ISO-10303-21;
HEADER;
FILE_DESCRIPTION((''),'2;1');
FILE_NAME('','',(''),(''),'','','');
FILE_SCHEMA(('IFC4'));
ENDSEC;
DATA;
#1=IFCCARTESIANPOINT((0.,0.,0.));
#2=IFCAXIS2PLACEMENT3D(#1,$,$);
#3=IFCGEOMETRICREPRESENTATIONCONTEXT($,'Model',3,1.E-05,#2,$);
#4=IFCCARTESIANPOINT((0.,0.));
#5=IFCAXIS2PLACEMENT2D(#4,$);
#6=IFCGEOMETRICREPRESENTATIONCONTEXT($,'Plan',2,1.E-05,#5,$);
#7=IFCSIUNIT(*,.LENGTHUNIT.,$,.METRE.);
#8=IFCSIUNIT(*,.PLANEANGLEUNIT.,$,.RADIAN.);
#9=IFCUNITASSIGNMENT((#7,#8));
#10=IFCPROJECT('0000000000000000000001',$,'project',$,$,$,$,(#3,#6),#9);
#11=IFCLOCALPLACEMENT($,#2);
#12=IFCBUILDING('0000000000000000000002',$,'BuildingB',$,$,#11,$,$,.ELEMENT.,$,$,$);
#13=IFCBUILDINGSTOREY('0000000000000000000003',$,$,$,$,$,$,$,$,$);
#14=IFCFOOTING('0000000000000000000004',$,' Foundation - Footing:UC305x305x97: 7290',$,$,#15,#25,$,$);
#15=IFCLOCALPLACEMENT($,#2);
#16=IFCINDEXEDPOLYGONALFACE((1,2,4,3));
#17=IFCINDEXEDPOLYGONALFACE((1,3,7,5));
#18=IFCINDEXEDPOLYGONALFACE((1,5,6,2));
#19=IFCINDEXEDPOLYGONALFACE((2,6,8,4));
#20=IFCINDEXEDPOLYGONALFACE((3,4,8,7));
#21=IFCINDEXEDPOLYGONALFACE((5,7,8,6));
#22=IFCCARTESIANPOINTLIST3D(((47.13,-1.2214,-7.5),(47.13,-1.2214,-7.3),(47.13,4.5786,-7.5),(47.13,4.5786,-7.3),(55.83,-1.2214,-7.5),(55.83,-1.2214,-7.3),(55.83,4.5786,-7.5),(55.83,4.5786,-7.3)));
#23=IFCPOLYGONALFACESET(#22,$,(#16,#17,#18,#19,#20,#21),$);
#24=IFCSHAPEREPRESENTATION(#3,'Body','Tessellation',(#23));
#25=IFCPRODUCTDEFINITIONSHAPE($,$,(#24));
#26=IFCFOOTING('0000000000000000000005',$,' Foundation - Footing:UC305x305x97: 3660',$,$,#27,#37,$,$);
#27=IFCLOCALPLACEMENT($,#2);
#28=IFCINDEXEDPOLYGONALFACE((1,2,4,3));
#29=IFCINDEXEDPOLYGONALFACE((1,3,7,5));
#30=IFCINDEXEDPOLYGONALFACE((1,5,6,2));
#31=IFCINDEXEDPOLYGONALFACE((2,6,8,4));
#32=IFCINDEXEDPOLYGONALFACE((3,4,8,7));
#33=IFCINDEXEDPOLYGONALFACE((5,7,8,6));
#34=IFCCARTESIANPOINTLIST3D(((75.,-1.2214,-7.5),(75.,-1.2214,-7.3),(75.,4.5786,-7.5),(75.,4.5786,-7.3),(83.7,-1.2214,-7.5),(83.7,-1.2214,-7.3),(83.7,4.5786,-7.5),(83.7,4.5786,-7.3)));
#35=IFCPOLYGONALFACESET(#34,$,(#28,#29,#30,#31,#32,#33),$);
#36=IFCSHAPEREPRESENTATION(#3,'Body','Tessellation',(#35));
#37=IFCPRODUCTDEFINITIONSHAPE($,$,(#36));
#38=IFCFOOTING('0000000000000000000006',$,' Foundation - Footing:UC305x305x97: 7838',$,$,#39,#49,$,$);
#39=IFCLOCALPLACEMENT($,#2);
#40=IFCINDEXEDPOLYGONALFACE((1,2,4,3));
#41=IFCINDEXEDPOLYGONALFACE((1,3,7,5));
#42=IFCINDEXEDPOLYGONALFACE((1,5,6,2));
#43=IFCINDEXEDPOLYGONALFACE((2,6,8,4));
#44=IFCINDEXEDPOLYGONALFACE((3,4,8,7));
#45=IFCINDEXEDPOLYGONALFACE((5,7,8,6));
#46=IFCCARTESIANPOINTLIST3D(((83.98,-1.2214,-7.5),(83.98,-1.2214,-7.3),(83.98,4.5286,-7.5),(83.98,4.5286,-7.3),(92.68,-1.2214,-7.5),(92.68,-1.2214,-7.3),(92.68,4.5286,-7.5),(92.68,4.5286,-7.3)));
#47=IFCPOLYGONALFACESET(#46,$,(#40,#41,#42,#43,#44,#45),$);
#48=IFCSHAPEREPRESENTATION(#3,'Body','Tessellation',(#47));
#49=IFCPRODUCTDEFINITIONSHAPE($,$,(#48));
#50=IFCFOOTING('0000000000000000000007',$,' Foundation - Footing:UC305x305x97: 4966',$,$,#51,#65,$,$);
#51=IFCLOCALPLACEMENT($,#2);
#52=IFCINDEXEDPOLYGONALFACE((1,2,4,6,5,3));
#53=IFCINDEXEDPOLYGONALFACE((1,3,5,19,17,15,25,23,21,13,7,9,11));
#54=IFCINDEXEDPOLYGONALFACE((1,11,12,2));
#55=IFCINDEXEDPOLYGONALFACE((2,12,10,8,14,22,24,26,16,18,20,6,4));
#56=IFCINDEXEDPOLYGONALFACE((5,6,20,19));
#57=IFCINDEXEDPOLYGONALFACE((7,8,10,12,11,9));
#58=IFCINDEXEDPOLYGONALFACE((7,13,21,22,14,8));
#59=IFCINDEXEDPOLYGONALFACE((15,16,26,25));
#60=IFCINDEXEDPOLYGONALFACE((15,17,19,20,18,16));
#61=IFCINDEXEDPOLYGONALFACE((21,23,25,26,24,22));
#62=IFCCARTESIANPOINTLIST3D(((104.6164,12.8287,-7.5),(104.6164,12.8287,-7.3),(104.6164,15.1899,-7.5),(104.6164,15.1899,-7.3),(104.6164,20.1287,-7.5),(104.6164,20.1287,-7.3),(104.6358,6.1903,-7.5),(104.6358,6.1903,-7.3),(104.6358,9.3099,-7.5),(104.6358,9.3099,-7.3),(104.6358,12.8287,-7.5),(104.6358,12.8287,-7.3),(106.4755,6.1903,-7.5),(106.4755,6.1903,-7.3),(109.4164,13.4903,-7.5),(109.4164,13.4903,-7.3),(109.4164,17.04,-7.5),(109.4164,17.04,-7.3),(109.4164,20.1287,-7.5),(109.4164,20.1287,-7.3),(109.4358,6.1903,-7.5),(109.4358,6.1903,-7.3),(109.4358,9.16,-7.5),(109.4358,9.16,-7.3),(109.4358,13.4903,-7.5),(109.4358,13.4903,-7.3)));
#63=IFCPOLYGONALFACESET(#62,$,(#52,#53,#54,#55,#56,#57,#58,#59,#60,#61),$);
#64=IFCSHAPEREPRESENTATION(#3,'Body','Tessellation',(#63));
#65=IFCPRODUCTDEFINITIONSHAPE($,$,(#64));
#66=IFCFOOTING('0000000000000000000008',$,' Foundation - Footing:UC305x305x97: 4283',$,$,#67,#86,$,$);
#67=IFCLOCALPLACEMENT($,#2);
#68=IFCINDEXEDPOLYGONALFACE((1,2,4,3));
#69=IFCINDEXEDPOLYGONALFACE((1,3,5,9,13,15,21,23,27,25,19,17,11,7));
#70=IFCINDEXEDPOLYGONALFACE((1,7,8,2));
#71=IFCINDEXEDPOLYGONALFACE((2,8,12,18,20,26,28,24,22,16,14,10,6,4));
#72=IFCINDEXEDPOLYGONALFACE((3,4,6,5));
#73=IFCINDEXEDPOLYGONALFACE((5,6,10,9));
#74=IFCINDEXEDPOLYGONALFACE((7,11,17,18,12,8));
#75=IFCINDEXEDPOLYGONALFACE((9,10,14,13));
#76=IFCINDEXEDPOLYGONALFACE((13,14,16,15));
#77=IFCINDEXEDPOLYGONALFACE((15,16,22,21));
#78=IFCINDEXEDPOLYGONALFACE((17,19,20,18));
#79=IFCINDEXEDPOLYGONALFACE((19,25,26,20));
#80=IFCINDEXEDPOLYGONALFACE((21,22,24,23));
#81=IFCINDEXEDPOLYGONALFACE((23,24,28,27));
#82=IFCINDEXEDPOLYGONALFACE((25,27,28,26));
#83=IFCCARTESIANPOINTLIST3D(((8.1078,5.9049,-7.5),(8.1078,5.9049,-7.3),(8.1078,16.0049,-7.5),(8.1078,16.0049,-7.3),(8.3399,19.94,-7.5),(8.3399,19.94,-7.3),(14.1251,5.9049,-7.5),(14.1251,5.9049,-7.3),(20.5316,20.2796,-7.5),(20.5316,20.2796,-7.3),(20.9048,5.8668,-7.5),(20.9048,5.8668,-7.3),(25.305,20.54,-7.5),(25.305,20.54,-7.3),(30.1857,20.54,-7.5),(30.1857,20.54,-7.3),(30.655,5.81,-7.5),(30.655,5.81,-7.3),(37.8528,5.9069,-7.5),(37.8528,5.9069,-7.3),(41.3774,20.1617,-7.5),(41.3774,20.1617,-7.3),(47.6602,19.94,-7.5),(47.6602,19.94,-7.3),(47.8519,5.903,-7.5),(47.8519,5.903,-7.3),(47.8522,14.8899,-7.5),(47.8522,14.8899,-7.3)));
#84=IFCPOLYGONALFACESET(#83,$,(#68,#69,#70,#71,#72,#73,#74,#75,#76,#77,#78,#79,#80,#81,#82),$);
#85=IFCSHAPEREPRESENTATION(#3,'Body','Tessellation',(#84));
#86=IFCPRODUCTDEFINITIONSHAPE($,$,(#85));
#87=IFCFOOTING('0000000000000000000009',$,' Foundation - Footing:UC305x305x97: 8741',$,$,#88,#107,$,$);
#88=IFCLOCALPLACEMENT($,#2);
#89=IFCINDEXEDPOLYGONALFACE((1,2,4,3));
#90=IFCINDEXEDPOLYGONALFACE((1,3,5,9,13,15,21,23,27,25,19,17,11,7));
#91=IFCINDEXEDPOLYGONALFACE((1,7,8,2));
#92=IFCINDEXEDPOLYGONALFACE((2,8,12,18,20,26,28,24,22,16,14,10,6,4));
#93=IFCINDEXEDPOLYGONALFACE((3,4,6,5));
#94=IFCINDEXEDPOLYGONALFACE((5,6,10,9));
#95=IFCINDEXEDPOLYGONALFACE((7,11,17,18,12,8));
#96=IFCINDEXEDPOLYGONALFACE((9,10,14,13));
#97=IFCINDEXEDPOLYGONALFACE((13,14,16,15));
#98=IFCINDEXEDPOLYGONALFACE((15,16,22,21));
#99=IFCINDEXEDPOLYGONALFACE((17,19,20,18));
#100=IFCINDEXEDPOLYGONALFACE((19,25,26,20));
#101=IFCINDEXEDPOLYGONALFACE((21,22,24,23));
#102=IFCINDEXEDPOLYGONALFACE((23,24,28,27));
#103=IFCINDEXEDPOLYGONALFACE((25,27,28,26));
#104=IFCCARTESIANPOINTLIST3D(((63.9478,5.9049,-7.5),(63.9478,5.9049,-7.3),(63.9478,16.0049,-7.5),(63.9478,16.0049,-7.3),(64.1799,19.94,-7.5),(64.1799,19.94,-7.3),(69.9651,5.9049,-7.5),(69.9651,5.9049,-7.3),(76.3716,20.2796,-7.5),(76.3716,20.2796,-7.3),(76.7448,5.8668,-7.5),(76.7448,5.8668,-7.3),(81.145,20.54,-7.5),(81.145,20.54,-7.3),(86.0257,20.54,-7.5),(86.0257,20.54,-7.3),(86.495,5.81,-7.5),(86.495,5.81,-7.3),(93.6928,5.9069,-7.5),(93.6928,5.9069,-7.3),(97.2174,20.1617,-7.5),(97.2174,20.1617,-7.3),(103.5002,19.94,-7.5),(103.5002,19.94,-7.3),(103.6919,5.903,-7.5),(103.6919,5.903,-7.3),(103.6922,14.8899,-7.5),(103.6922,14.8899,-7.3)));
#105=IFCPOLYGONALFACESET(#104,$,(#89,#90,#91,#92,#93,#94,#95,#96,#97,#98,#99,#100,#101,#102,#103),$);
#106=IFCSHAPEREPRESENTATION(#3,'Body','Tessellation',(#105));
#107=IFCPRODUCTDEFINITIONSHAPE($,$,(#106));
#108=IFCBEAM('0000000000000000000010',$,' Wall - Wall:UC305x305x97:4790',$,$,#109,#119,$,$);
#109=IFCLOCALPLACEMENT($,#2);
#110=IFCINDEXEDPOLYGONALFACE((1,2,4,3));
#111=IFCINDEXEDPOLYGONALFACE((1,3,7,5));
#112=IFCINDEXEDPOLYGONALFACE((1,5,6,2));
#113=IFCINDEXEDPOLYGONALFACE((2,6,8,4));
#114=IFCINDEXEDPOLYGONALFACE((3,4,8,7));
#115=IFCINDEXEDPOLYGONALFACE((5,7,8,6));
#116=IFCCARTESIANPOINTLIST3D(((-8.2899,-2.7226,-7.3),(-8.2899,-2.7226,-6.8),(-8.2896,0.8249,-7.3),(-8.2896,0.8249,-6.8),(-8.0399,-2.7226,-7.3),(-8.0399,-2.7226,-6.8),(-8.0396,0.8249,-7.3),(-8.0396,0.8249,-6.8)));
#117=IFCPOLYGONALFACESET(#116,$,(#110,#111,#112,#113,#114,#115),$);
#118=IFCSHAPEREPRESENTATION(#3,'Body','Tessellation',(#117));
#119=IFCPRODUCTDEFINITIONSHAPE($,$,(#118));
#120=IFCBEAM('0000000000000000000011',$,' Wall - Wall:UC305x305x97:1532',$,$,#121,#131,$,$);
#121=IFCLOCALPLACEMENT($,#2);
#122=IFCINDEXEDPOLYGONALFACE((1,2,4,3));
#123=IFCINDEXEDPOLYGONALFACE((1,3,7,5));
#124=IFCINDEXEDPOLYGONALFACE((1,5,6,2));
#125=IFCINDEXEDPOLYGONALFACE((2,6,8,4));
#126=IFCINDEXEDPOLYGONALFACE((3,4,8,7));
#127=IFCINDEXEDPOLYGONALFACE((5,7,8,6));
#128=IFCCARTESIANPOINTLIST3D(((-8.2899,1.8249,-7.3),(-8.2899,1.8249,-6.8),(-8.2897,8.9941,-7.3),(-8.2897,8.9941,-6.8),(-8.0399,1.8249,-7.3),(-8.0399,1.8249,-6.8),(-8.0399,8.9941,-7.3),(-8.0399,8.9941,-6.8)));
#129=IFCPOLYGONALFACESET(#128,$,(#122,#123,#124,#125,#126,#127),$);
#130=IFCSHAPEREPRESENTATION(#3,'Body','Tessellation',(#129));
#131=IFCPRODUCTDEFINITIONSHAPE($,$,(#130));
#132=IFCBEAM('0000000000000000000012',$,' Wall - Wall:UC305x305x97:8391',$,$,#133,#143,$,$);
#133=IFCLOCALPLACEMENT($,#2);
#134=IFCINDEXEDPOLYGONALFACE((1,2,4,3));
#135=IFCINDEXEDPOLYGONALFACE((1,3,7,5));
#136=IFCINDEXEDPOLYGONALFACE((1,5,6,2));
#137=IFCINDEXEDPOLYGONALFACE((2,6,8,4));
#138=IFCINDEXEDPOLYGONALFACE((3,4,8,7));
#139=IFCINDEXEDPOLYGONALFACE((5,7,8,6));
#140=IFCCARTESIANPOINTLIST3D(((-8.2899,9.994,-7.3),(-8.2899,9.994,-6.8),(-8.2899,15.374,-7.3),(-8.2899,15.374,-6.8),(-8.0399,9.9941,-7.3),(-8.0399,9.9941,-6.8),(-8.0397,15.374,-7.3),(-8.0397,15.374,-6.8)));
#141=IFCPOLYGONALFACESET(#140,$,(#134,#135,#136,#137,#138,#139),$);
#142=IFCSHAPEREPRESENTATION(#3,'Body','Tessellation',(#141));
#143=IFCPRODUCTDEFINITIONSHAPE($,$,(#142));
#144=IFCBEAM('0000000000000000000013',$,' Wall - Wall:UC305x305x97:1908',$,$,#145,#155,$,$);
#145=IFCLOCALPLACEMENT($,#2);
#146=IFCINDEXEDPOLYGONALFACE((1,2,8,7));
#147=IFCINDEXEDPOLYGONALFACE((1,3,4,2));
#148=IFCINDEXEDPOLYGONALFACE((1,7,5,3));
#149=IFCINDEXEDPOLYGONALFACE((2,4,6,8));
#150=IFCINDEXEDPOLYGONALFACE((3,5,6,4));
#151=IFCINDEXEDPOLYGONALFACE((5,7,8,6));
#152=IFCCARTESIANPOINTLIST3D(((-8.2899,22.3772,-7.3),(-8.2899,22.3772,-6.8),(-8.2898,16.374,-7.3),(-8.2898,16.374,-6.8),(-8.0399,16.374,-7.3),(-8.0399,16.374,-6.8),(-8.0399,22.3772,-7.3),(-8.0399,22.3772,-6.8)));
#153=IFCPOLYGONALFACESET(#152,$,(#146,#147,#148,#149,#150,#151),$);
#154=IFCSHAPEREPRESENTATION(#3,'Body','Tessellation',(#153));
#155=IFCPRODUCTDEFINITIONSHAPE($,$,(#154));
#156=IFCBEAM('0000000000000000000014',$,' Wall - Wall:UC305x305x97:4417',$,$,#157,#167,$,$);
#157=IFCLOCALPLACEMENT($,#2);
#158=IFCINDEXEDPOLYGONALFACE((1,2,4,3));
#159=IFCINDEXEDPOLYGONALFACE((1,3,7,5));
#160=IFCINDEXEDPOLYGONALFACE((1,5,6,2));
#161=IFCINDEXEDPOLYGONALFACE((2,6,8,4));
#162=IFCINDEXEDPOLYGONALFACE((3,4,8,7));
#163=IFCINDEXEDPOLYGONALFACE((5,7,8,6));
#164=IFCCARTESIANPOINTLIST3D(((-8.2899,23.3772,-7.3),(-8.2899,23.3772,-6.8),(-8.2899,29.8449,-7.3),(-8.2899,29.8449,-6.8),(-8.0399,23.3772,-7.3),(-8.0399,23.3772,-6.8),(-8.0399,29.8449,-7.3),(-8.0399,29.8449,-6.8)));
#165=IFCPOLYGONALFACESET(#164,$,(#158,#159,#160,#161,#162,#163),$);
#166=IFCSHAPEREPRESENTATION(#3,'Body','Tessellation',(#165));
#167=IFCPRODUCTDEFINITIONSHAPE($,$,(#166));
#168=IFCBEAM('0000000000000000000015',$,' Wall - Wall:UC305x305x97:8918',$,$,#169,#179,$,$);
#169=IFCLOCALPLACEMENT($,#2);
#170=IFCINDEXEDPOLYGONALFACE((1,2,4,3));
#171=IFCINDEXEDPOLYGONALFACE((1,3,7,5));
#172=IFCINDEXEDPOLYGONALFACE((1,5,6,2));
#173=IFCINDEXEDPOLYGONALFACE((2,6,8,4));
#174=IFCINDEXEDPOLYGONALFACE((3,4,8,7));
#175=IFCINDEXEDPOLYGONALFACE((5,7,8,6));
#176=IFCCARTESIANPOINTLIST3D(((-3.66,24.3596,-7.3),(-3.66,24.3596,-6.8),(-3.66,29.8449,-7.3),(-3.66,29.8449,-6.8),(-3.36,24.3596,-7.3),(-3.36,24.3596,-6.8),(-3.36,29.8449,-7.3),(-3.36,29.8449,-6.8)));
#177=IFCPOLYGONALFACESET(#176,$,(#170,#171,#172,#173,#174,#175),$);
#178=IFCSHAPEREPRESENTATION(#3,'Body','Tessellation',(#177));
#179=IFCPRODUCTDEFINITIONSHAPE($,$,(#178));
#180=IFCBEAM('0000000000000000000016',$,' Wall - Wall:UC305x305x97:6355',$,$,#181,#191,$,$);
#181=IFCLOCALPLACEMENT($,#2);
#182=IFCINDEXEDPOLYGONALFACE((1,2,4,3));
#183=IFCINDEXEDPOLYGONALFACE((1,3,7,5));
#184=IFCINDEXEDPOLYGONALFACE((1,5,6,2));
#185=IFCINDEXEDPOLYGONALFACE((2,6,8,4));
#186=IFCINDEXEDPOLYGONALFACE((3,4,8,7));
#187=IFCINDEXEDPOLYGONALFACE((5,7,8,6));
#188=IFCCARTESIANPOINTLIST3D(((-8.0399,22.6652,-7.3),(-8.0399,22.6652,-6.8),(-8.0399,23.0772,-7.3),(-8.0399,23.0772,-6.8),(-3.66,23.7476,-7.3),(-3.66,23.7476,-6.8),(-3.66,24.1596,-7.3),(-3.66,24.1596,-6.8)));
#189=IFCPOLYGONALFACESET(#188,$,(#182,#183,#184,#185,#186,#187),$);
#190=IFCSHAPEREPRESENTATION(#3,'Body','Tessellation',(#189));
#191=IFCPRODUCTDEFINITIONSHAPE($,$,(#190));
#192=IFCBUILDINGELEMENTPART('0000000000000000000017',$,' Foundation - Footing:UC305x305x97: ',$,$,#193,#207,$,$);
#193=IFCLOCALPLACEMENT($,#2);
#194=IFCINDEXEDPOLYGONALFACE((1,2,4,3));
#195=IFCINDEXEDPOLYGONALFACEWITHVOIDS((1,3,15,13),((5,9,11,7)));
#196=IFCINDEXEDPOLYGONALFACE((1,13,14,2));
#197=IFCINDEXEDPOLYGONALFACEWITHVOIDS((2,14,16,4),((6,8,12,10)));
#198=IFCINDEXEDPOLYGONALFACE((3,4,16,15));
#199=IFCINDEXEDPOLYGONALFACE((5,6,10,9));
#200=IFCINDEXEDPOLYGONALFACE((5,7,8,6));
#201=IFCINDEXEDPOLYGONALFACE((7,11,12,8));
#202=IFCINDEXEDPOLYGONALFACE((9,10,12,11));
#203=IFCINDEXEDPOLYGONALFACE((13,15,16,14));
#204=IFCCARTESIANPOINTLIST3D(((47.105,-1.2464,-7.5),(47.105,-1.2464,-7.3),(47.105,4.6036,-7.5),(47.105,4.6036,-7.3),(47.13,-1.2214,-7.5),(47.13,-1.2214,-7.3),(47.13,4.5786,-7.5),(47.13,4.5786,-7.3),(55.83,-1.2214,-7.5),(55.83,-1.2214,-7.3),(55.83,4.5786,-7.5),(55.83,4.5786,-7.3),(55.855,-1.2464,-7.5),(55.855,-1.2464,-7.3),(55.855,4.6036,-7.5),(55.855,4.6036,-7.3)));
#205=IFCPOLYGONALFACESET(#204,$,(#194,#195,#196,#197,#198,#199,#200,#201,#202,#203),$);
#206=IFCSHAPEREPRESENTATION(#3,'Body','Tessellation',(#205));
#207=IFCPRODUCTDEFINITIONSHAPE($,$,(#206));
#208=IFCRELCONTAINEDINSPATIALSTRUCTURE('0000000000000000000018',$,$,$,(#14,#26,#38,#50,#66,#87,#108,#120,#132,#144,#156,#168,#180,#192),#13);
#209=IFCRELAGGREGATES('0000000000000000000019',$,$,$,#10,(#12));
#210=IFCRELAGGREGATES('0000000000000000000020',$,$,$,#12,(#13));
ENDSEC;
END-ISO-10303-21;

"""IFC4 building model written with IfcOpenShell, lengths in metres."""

from ifc_helpers import new_model, si_unit, origin, origin_2d, place, context, project, spatial, polyline, outline, extrude, element, save


model = new_model("IFC4")

# Units and contexts
model_context = context("Model", 3, precision=1e-05, world=origin())
plan_context = context("Plan", 2, precision=1e-05, world=origin_2d())
ifc_project = project(units=[si_unit("LENGTHUNIT", "METRE"), si_unit("PLANEANGLEUNIT", "RADIAN")], contexts=[model_context, plan_context])

# Building, storey
building_placement = place(None, origin())
building = spatial("IfcBuilding", under=ifc_project, at=building_placement, Name="BuildingB", CompositionType="ELEMENT")
storey = spatial("IfcBuildingStorey", under=building)

# Footings
element("IfcFooting", 1, inside=storey, Name=" Foundation - Footing:UC305x305x97: 7290", context=model_context, shape_type="SweptSolid", body=[
    extrude(outline(polyline([(47.13, -1.2214, -7.5), (55.83, -1.2214, -7.5), (55.83, 4.5786, -7.5), (47.13, 4.5786, -7.5), (47.13, -1.2214, -7.5)])), None, (0.0, 0.0, 1.0), 0.2),
])
element("IfcFooting", 2, inside=storey, Name=" Foundation - Footing:UC305x305x97: 3660", context=model_context, shape_type="SweptSolid", body=[
    extrude(outline(polyline([(75.0, -1.2214, -7.5), (83.7, -1.2214, -7.5), (83.7, 4.5786, -7.5), (75.0, 4.5786, -7.5), (75.0, -1.2214, -7.5)])), None, (0.0, 0.0, 1.0), 0.2),
])
element("IfcFooting", 3, inside=storey, Name=" Foundation - Footing:UC305x305x97: 7838", context=model_context, shape_type="SweptSolid", body=[
    extrude(outline(polyline([(92.68, -1.2214, -7.5), (83.98, -1.2214, -7.5), (83.98, 4.5286, -7.5), (92.68, 4.5286, -7.5), (92.68, -1.2214, -7.5)])), None, (0.0, 0.0, 1.0), 0.2),
])
element("IfcFooting", 4, inside=storey, Name=" Foundation - Footing:UC305x305x97: 4966", context=model_context, shape_type="SweptSolid", body=[
    extrude(outline(polyline([(104.6358, 12.8287, -7.5), (104.6164, 12.8287, -7.5), (104.6164, 15.1899, -7.5), (104.6164, 20.1287, -7.5), (109.4164, 20.1287, -7.5), (109.4164, 17.04, -7.5), (109.4164, 13.4903, -7.5), (109.4358, 13.4903, -7.5), (109.4358, 9.16, -7.5), (109.4358, 6.1903, -7.5), (106.4755, 6.1903, -7.5), (104.6358, 6.1903, -7.5), (104.6358, 9.3099, -7.5), (104.6358, 12.8287, -7.5)])), None, (0.0, 0.0, 1.0), 0.2),
])
element("IfcFooting", 5, inside=storey, Name=" Foundation - Footing:UC305x305x97: 4283", context=model_context, shape_type="SweptSolid", body=[
    extrude(outline(polyline([(8.3399, 19.94, -7.5), (20.5316, 20.2796, -7.5), (25.305, 20.54, -7.5), (30.1857, 20.54, -7.5), (41.3774, 20.1617, -7.5), (47.6602, 19.94, -7.5), (47.8522, 14.8899, -7.5), (47.8519, 5.903, -7.5), (37.8528, 5.9069, -7.5), (30.655, 5.81, -7.5), (20.9048, 5.8668, -7.5), (14.1251, 5.9049, -7.5), (8.1078, 5.9049, -7.5), (8.1078, 16.0049, -7.5), (8.3399, 19.94, -7.5)])), None, (0.0, 0.0, 1.0), 0.2),
])
element("IfcFooting", 6, inside=storey, Name=" Foundation - Footing:UC305x305x97: 8741", context=model_context, shape_type="SweptSolid", body=[
    extrude(outline(polyline([(64.1799, 19.94, -7.5), (76.3716, 20.2796, -7.5), (81.145, 20.54, -7.5), (86.0257, 20.54, -7.5), (97.2174, 20.1617, -7.5), (103.5002, 19.94, -7.5), (103.6922, 14.8899, -7.5), (103.6919, 5.903, -7.5), (93.6928, 5.9069, -7.5), (86.495, 5.81, -7.5), (76.7448, 5.8668, -7.5), (69.9651, 5.9049, -7.5), (63.9478, 5.9049, -7.5), (63.9478, 16.0049, -7.5), (64.1799, 19.94, -7.5)])), None, (0.0, 0.0, 1.0), 0.2),
])

# Beams
element("IfcBeam", 7, inside=storey, Name=" Wall - Wall:UC305x305x97:4790", context=model_context, shape_type="SweptSolid", body=[
    extrude(outline(polyline([(-8.2899, -2.7226, -7.3), (-8.0399, -2.7226, -7.3), (-8.0396, 0.8249, -7.3), (-8.2896, 0.8249, -7.3), (-8.2899, -2.7226, -7.3)])), None, (0.0, 0.0, 1.0), 0.5),
])
element("IfcBeam", 8, inside=storey, Name=" Wall - Wall:UC305x305x97:1532", context=model_context, shape_type="SweptSolid", body=[
    extrude(outline(polyline([(-8.2899, 1.8249, -7.3), (-8.0399, 1.8249, -7.3), (-8.0399, 8.9941, -7.3), (-8.2897, 8.9941, -7.3), (-8.2899, 1.8249, -7.3)])), None, (0.0, 0.0, 1.0), 0.5),
])
element("IfcBeam", 9, inside=storey, Name=" Wall - Wall:UC305x305x97:8391", context=model_context, shape_type="SweptSolid", body=[
    extrude(outline(polyline([(-8.2899, 9.994, -7.3), (-8.0399, 9.9941, -7.3), (-8.0397, 15.374, -7.3), (-8.2899, 15.374, -7.3), (-8.2899, 9.994, -7.3)])), None, (0.0, 0.0, 1.0), 0.5),
])
element("IfcBeam", 10, inside=storey, Name=" Wall - Wall:UC305x305x97:1908", context=model_context, shape_type="SweptSolid", body=[
    extrude(outline(polyline([(-8.2898, 16.374, -7.3), (-8.0399, 16.374, -7.3), (-8.0399, 22.3772, -7.3), (-8.2899, 22.3772, -7.3), (-8.2898, 16.374, -7.3)])), None, (0.0, 0.0, 1.0), 0.5),
])
element("IfcBeam", 11, inside=storey, Name=" Wall - Wall:UC305x305x97:4417", context=model_context, shape_type="SweptSolid", body=[
    extrude(outline(polyline([(-8.2899, 23.3772, -7.3), (-8.0399, 23.3772, -7.3), (-8.0399, 29.8449, -7.3), (-8.2899, 29.8449, -7.3), (-8.2899, 23.3772, -7.3)])), None, (0.0, 0.0, 1.0), 0.5),
])
element("IfcBeam", 12, inside=storey, Name=" Wall - Wall:UC305x305x97:8918", context=model_context, shape_type="SweptSolid", body=[
    extrude(outline(polyline([(-3.66, 29.8449, -7.3), (-3.36, 29.8449, -7.3), (-3.36, 24.3596, -7.3), (-3.66, 24.3596, -7.3), (-3.66, 29.8449, -7.3)])), None, (0.0, 0.0, 1.0), 0.5),
])
element("IfcBeam", 13, inside=storey, Name=" Wall - Wall:UC305x305x97:6355", context=model_context, shape_type="SweptSolid", body=[
    extrude(outline(polyline([(-3.66, 24.1596, -7.3), (-3.66, 23.7476, -7.3), (-8.0399, 22.6652, -7.3), (-8.0399, 23.0772, -7.3), (-3.66, 24.1596, -7.3)])), None, (0.0, 0.0, 1.0), 0.5),
])

# Building element part, opening
building_element_part_1 = element("IfcBuildingElementPart", 14, inside=storey, Name=" Foundation - Footing:UC305x305x97: ", context=model_context, shape_type="SweptSolid", body=[
    extrude(outline(polyline([(47.105, -1.2464, -7.5), (55.855, -1.2464, -7.5), (55.855, 4.6036, -7.5), (47.105, 4.6036, -7.5), (47.105, -1.2464, -7.5)])), None, (0.0, 0.0, 1.0), 0.2),
])
element("IfcOpeningElement", 15, inside=storey, cuts=building_element_part_1, context=model_context, shape_type="SweptSolid", body=[
    extrude(outline(polyline([(47.13, -1.2214, -7.5), (55.83, -1.2214, -7.5), (55.83, 4.5786, -7.5), (47.13, 4.5786, -7.5), (47.13, -1.2214, -7.5)])), None, (0.0, 0.0, 1.0), 0.2),
])

save(model, "model.ifc")
